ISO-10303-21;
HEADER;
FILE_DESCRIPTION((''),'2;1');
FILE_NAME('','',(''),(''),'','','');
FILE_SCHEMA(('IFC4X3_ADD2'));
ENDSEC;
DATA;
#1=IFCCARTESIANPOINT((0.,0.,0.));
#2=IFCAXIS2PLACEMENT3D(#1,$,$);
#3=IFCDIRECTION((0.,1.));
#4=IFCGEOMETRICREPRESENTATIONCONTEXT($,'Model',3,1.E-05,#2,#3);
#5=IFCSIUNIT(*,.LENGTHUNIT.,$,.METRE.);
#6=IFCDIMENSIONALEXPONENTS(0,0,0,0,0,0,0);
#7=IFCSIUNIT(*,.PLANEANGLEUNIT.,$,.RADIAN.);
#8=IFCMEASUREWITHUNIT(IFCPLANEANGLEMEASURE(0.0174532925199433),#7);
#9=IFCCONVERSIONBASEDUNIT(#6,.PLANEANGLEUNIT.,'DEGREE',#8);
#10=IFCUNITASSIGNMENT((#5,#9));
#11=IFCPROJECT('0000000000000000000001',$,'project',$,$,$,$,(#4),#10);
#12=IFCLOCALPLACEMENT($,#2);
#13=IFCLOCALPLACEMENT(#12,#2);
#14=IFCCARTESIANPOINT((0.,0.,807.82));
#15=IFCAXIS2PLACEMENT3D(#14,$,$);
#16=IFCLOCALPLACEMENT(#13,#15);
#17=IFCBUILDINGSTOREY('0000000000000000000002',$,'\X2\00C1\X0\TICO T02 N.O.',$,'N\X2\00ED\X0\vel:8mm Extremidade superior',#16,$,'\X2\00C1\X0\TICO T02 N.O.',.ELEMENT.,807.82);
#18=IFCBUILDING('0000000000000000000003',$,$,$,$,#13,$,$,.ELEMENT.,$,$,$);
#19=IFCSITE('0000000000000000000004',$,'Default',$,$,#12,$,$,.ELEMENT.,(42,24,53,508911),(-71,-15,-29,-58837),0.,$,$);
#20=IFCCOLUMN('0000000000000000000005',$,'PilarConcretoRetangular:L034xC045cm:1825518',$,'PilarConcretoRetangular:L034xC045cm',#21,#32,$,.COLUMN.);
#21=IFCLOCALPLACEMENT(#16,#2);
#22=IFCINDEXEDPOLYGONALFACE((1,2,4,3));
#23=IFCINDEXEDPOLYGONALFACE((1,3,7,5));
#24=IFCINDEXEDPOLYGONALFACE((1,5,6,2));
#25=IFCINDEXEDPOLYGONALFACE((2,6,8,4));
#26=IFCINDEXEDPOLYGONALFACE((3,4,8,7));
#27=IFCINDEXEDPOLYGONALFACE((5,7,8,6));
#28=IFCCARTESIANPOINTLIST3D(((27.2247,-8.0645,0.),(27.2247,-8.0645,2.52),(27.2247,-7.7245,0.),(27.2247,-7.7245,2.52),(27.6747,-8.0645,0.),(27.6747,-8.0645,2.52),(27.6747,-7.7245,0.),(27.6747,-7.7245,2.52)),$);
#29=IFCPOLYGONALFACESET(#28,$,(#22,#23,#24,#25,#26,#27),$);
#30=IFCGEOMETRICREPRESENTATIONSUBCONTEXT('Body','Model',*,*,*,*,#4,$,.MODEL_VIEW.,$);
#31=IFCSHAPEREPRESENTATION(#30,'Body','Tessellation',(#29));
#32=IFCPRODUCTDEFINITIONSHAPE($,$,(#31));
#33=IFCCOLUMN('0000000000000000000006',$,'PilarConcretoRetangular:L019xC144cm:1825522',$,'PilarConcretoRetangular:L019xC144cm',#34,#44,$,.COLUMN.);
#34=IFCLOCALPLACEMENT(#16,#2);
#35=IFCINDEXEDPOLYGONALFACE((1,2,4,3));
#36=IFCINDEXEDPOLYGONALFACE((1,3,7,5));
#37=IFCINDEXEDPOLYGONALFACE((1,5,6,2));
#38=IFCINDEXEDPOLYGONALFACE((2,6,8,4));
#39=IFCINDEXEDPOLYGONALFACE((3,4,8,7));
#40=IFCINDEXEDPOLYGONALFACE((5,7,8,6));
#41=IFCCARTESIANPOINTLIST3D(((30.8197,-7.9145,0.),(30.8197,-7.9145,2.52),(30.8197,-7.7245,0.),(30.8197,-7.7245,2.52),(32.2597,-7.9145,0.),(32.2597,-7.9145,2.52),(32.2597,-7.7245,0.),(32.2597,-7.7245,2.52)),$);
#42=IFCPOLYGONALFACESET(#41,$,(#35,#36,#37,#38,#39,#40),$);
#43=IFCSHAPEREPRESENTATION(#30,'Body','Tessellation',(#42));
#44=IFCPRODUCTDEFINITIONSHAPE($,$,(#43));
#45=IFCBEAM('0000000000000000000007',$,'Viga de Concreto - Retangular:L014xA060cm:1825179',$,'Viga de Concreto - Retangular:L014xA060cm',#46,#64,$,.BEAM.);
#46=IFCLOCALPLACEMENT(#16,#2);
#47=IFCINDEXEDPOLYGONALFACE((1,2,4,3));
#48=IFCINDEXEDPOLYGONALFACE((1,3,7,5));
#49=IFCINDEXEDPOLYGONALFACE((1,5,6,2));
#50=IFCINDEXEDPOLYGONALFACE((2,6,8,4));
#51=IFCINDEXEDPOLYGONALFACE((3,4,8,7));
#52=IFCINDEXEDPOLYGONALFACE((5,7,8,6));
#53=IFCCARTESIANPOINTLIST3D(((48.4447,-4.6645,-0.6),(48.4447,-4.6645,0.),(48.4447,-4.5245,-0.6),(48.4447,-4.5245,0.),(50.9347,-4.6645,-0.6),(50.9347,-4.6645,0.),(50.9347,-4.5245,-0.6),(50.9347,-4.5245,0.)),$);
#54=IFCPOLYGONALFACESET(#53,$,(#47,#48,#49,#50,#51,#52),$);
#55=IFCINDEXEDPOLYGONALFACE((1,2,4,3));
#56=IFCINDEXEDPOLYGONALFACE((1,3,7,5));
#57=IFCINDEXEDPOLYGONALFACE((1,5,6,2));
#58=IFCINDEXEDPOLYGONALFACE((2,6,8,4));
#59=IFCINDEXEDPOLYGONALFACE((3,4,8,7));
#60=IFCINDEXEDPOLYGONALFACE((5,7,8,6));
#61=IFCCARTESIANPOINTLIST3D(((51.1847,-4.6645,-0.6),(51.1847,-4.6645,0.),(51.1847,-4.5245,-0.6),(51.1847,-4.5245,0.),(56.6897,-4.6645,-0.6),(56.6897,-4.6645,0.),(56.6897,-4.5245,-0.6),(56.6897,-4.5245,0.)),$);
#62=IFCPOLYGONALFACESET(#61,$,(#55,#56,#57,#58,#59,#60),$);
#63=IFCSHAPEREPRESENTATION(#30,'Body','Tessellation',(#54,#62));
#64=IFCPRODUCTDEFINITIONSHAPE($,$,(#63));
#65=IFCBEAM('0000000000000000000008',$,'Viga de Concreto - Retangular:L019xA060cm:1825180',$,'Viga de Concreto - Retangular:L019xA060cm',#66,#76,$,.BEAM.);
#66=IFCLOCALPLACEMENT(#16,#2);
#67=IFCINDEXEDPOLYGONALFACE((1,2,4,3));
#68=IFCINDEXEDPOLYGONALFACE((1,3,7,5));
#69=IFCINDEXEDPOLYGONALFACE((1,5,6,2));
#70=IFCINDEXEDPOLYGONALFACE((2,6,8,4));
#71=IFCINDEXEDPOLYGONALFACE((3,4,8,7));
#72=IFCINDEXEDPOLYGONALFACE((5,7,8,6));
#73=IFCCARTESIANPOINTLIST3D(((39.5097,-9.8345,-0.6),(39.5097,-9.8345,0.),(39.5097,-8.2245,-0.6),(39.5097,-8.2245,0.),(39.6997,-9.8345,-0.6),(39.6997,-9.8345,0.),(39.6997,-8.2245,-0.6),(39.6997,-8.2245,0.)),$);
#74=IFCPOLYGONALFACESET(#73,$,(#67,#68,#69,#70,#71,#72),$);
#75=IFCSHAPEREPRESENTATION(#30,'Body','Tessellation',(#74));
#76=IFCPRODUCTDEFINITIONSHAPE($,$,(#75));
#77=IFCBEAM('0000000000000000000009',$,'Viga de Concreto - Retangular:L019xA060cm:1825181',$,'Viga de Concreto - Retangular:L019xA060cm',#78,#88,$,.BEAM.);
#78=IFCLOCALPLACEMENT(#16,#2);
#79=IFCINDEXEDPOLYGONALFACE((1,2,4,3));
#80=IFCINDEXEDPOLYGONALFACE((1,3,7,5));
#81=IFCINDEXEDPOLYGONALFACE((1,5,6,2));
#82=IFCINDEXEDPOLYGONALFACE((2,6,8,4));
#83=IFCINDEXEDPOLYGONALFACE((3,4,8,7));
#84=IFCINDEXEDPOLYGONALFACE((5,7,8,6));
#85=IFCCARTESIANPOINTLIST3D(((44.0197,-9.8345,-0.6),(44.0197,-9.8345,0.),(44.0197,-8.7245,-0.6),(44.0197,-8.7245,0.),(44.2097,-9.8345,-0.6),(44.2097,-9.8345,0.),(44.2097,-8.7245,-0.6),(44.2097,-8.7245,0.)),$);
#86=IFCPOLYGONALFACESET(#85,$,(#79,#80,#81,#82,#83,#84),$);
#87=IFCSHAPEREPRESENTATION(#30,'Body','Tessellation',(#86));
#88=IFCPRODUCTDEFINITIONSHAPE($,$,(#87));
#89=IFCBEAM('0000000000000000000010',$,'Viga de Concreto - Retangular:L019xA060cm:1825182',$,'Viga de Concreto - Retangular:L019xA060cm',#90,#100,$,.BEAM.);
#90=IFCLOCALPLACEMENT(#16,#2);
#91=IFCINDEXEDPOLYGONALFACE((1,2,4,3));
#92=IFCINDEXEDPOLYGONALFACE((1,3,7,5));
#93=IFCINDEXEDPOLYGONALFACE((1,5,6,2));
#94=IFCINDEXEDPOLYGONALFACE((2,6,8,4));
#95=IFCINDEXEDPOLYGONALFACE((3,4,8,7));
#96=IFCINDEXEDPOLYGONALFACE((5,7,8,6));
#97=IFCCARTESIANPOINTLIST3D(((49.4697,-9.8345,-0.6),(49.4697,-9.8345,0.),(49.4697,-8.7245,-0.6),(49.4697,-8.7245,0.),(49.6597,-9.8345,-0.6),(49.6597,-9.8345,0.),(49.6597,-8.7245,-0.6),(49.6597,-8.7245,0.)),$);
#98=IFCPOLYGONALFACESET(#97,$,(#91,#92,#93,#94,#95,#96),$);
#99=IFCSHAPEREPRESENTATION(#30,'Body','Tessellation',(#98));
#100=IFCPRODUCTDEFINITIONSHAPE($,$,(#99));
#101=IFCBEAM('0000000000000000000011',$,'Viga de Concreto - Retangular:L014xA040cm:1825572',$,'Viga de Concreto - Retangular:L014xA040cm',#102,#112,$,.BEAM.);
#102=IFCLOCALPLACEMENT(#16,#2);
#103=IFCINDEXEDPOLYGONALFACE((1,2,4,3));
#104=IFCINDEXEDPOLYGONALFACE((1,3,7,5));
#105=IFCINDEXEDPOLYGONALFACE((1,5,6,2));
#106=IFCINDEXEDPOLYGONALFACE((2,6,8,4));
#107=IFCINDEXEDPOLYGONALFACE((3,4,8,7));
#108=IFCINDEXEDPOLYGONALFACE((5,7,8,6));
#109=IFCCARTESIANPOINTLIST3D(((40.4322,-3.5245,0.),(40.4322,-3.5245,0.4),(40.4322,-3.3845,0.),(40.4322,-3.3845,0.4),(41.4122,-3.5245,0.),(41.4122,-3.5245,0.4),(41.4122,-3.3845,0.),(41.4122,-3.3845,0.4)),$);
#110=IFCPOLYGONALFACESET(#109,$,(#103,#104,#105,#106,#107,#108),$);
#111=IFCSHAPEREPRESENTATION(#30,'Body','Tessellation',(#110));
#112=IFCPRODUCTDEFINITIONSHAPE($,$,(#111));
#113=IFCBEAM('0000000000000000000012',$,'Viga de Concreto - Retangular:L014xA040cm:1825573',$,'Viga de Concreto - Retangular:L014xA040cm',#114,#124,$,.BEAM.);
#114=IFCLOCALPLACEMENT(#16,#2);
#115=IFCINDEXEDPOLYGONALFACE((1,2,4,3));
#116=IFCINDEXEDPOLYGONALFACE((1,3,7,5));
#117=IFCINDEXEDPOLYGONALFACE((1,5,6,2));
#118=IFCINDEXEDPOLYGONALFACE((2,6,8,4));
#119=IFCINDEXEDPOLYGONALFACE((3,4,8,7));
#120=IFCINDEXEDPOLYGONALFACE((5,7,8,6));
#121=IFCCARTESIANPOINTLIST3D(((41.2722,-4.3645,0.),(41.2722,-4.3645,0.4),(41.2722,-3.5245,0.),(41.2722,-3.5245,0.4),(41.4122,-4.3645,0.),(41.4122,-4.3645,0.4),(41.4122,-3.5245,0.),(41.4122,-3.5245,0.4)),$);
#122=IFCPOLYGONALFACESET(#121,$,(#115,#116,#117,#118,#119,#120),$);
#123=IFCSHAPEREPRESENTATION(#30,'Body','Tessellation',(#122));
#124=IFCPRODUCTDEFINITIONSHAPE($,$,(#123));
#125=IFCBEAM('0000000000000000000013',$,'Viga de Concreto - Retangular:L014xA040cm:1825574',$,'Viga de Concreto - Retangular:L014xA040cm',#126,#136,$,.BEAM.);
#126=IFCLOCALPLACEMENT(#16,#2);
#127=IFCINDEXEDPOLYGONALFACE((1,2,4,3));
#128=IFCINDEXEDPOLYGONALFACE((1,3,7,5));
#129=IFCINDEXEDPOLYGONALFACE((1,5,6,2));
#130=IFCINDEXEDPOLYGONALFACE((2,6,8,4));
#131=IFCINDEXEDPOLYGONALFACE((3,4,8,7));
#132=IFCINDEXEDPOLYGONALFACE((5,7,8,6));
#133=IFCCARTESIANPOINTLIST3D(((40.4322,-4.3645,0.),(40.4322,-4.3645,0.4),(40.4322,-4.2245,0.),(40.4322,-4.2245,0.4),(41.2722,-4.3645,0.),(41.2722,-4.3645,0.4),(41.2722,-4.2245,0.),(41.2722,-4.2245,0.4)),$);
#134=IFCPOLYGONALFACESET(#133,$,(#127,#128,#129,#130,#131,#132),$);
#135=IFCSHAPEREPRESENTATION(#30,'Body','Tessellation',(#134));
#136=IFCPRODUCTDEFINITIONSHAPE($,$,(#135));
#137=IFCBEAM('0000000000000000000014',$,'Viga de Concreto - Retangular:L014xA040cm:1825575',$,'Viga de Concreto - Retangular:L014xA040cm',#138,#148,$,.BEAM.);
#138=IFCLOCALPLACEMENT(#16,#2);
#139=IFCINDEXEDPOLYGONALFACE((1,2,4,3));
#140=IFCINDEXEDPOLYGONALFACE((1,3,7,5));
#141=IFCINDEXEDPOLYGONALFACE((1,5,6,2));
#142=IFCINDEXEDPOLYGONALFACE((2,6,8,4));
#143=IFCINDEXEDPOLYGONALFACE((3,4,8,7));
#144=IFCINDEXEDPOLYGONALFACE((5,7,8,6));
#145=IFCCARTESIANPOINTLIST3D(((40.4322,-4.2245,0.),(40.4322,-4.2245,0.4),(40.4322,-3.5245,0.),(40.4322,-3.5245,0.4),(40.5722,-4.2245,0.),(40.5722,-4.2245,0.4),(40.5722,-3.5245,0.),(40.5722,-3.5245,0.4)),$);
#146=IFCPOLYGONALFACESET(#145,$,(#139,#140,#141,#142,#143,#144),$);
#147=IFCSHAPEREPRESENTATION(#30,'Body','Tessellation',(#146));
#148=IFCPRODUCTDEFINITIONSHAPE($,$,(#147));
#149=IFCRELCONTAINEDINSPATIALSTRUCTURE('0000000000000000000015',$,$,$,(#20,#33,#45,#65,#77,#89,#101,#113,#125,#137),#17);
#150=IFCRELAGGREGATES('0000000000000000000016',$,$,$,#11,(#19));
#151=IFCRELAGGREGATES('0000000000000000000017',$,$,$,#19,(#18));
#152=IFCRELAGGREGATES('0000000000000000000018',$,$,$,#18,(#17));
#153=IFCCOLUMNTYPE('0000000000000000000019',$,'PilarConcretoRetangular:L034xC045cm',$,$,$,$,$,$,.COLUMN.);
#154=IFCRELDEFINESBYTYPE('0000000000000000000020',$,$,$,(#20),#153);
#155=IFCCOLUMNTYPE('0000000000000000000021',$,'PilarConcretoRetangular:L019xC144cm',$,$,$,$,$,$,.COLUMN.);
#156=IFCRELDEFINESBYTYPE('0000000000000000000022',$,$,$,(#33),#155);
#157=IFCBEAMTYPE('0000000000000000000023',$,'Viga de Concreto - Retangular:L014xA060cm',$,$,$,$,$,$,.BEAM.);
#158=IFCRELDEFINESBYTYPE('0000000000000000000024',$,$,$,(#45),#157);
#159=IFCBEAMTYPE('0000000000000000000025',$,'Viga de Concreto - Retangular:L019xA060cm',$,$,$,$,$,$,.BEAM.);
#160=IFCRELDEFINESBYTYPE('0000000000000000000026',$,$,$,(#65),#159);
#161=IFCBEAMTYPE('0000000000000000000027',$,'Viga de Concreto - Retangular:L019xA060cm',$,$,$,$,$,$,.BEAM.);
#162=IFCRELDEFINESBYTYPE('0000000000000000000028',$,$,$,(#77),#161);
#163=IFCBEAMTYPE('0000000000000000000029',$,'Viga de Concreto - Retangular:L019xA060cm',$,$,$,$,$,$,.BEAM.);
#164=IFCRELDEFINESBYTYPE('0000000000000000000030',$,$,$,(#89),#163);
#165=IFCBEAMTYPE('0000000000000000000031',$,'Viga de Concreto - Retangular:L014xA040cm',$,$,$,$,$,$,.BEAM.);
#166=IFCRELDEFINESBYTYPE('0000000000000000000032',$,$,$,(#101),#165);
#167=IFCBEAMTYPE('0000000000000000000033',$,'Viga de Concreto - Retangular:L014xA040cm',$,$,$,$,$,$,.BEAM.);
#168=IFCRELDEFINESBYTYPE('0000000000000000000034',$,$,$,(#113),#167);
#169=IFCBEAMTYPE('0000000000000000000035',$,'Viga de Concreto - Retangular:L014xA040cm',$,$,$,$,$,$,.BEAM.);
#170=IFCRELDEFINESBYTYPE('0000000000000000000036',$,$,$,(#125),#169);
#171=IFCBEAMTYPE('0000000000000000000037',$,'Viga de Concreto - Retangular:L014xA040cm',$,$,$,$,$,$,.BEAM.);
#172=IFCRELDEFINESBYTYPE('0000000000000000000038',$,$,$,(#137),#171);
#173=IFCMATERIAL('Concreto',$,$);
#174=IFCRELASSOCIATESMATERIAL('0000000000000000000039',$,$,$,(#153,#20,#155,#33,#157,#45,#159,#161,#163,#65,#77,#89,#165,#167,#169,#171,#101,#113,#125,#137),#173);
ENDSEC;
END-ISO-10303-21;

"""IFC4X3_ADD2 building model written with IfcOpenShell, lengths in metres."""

from ifc_helpers import new_model, entity, si_unit, converted_unit, direction, frame, frame_2d, origin, origin_2d_with_axis, place, context, subcontext, project, spatial, rectangle, extrude, source, transform, mapped, material, material_profile, profile_set, profile_usage, type_object, type_shapes, element, save


model = new_model("IFC4X3_ADD2")

# Units and contexts
model_context = context("Model", 3, precision=1e-05, world=origin(), true_north=direction((0.0, 1.0)))
body_context = subcontext(model_context, "Body", "Model", "MODEL_VIEW")
ifc_project = project(units=[si_unit("LENGTHUNIT", "METRE"), converted_unit("PLANEANGLEUNIT", "DEGREE", entity("IfcPlaneAngleMeasure", 0.0174532925199433), si_unit("PLANEANGLEUNIT", "RADIAN"), dimensions=[0, 0, 0, 0, 0, 0, 0])], contexts=[model_context])

# Site, building, storey
site_placement = place(None, origin())
site = spatial("IfcSite", under=ifc_project, at=site_placement, Name="Default", CompositionType="ELEMENT", RefLatitude=(42, 24, 53, 508911), RefLongitude=(-71, -15, -29, -58837), RefElevation=0.0)
building_placement = place(site_placement, origin())
building = spatial("IfcBuilding", under=site, at=building_placement, CompositionType="ELEMENT")
storey_placement = place(building_placement, frame((0.0, 0.0, 807.82)))
storey = spatial("IfcBuildingStorey", under=building, at=storey_placement, Name="ÁTICO T02 N.O.", ObjectType="Nível:8mm Extremidade superior", LongName="ÁTICO T02 N.O.", CompositionType="ELEMENT", Elevation=807.82)

# Columns
ifc_material = material(Name="Concreto")
ifc_material_profile_1 = material_profile(ifc_material, rectangle(XDim=0.34, YDim=0.45, at=origin_2d_with_axis()), Name="L034xC045cm")
ifc_profile_set_1 = profile_set([ifc_material_profile_1], Name="L034xC045cm")
ifc_profile_usage_1 = profile_usage(ifc_profile_set_1)
column_type_1 = type_object("IfcColumnType", Name="PilarConcretoRetangular:L034xC045cm", PredefinedType="COLUMN", material=ifc_profile_set_1)
shared_shape_1 = source(origin(), body_context, "Body", "SweptSolid", [
    extrude(rectangle(XDim=0.34, YDim=0.45, at=origin_2d_with_axis()), frame((27.4497, -7.8945, 807.82), z_axis=(0.0, 0.0, 1.0), x_axis=(0.0, -1.0, 0.0)), (0.0, 0.0, 1.0), 2.52),
])
type_shapes(column_type_1, [shared_shape_1])
column_1_placement = place(storey_placement, frame((0.0, 0.0, -807.82)))
element("IfcColumn", 1, at=column_1_placement, inside=storey, type_object=column_type_1, material=ifc_profile_usage_1, Name="PilarConcretoRetangular:L034xC045cm:1825518", ObjectType="PilarConcretoRetangular:L034xC045cm", PredefinedType="COLUMN", context=body_context, shape_type="MappedRepresentation", body=[
    mapped(shared_shape_1, transform((0.0, 0.0, 0.0), scale=1.0)),
])
ifc_material_profile_2 = material_profile(ifc_material, rectangle(XDim=0.19, YDim=1.44, at=frame_2d((0.0, 0.0), x_axis=(1.0, 0.0))), Name="L019xC144cm")
ifc_profile_set_2 = profile_set([ifc_material_profile_2], Name="L019xC144cm")
ifc_profile_usage_2 = profile_usage(ifc_profile_set_2)
column_type_2 = type_object("IfcColumnType", Name="PilarConcretoRetangular:L019xC144cm", PredefinedType="COLUMN", material=ifc_profile_set_2)
shared_shape_2 = source(origin(), body_context, "Body", "SweptSolid", [
    extrude(rectangle(XDim=0.19, YDim=1.44, at=frame_2d((0.0, 0.0), x_axis=(1.0, 0.0))), frame((31.5397, -7.8195, 807.82), z_axis=(0.0, 0.0, 1.0), x_axis=(0.0, 1.0, 0.0)), (0.0, 0.0, 1.0), 2.52),
])
type_shapes(column_type_2, [shared_shape_2])
column_2_placement = place(storey_placement, frame((0.0, 0.0, -807.82)))
element("IfcColumn", 2, at=column_2_placement, inside=storey, type_object=column_type_2, material=ifc_profile_usage_2, Name="PilarConcretoRetangular:L019xC144cm:1825522", ObjectType="PilarConcretoRetangular:L019xC144cm", PredefinedType="COLUMN", context=body_context, shape_type="MappedRepresentation", body=[
    mapped(shared_shape_2, transform((0.0, 0.0, 0.0), scale=1.0)),
])

# Beams
ifc_material_profile_3 = material_profile(ifc_material, rectangle(XDim=0.6, YDim=0.14, at=origin_2d_with_axis()), Name="L014xA060cm")
ifc_profile_set_3 = profile_set([ifc_material_profile_3], Name="L014xA060cm")
ifc_profile_usage_3 = profile_usage(ifc_profile_set_3, cardinal=8)
beam_type_1 = type_object("IfcBeamType", Name="Viga de Concreto - Retangular:L014xA060cm", PredefinedType="BEAM", material=ifc_profile_set_3)
shared_shape_3 = source(origin(), body_context, "Body", "SweptSolid", [
    extrude(rectangle(XDim=0.6, YDim=0.14, at=origin_2d_with_axis()), frame((48.4447, -4.5945, 807.52), z_axis=(1.0, 0.0, 0.0), x_axis=(0.0, 0.0, -1.0)), (0.0, 0.0, 1.0), 2.49),
    extrude(rectangle(XDim=0.6, YDim=0.14, at=frame_2d((0.0, 0.0), x_axis=(1.0, 0.0))), frame((51.1847, -4.5945, 807.52), z_axis=(1.0, 0.0, 0.0), x_axis=(0.0, 0.0, -1.0)), (0.0, 0.0, 1.0), 5.505),
])
type_shapes(beam_type_1, [shared_shape_3])
beam_1_placement = place(storey_placement, frame((0.0, 0.0, -807.82)))
element("IfcBeam", 3, at=beam_1_placement, inside=storey, type_object=beam_type_1, material=ifc_profile_usage_3, Name="Viga de Concreto - Retangular:L014xA060cm:1825179", ObjectType="Viga de Concreto - Retangular:L014xA060cm", PredefinedType="BEAM", context=body_context, shape_type="MappedRepresentation", body=[
    mapped(shared_shape_3, transform((0.0, 0.0, 0.0), scale=1.0)),
])
ifc_material_profile_4 = material_profile(ifc_material, rectangle(XDim=0.6, YDim=0.19, at=origin_2d_with_axis()), Name="L019xA060cm")
ifc_profile_set_4 = profile_set([ifc_material_profile_4], Name="L019xA060cm")
ifc_profile_usage_4 = profile_usage(ifc_profile_set_4, cardinal=8)
beam_type_2 = type_object("IfcBeamType", Name="Viga de Concreto - Retangular:L019xA060cm", PredefinedType="BEAM", material=ifc_profile_set_4)
shared_shape_4 = source(origin(), body_context, "Body", "SweptSolid", [
    extrude(rectangle(XDim=0.6, YDim=0.19, at=frame_2d((0.0, 0.0), x_axis=(0.0, 1.0))), frame((39.6047, -8.2245, 807.52), z_axis=(0.0, -1.0, 0.0), x_axis=(-1.0, 0.0, 0.0)), (0.0, 0.0, 1.0), 1.61),
])
type_shapes(beam_type_2, [shared_shape_4])
beam_2_placement = place(storey_placement, frame((0.0, 0.0, -807.82)))
element("IfcBeam", 4, at=beam_2_placement, inside=storey, type_object=beam_type_2, material=ifc_profile_usage_4, Name="Viga de Concreto - Retangular:L019xA060cm:1825180", ObjectType="Viga de Concreto - Retangular:L019xA060cm", PredefinedType="BEAM", context=body_context, shape_type="MappedRepresentation", body=[
    mapped(shared_shape_4, transform((0.0, 0.0, 0.0), scale=1.0)),
])
beam_type_3 = type_object("IfcBeamType", Name="Viga de Concreto - Retangular:L019xA060cm", PredefinedType="BEAM", material=ifc_profile_set_4)
shared_shape_5 = source(origin(), body_context, "Body", "SweptSolid", [
    extrude(rectangle(XDim=0.6, YDim=0.19, at=frame_2d((0.0, 0.0), x_axis=(0.0, 1.0))), frame((44.1147, -8.7245, 807.52), z_axis=(0.0, -1.0, 0.0), x_axis=(-1.0, 0.0, 0.0)), (0.0, 0.0, 1.0), 1.11),
])
type_shapes(beam_type_3, [shared_shape_5])
beam_3_placement = place(storey_placement, frame((0.0, 0.0, -807.82)))
element("IfcBeam", 5, at=beam_3_placement, inside=storey, type_object=beam_type_3, material=ifc_profile_usage_4, Name="Viga de Concreto - Retangular:L019xA060cm:1825181", ObjectType="Viga de Concreto - Retangular:L019xA060cm", PredefinedType="BEAM", context=body_context, shape_type="MappedRepresentation", body=[
    mapped(shared_shape_5, transform((0.0, 0.0, 0.0), scale=1.0)),
])
beam_type_4 = type_object("IfcBeamType", Name="Viga de Concreto - Retangular:L019xA060cm", PredefinedType="BEAM", material=ifc_profile_set_4)
shared_shape_6 = source(origin(), body_context, "Body", "SweptSolid", [
    extrude(rectangle(XDim=0.6, YDim=0.19, at=frame_2d((0.0, 0.0), x_axis=(0.0, 1.0))), frame((49.5647, -8.7245, 807.52), z_axis=(0.0, -1.0, 0.0), x_axis=(-1.0, 0.0, 0.0)), (0.0, 0.0, 1.0), 1.11),
])
type_shapes(beam_type_4, [shared_shape_6])
beam_4_placement = place(storey_placement, frame((0.0, 0.0, -807.82)))
element("IfcBeam", 6, at=beam_4_placement, inside=storey, type_object=beam_type_4, material=ifc_profile_usage_4, Name="Viga de Concreto - Retangular:L019xA060cm:1825182", ObjectType="Viga de Concreto - Retangular:L019xA060cm", PredefinedType="BEAM", context=body_context, shape_type="MappedRepresentation", body=[
    mapped(shared_shape_6, transform((0.0, 0.0, 0.0), scale=1.0)),
])
ifc_material_profile_5 = material_profile(ifc_material, rectangle(XDim=0.4, YDim=0.14, at=frame_2d((0.0, 0.0), x_axis=(0.0, 1.0))), Name="L014xA040cm")
ifc_profile_set_5 = profile_set([ifc_material_profile_5], Name="L014xA040cm")
ifc_profile_usage_5 = profile_usage(ifc_profile_set_5, cardinal=8)
beam_type_5 = type_object("IfcBeamType", Name="Viga de Concreto - Retangular:L014xA040cm", PredefinedType="BEAM", material=ifc_profile_set_5)
shared_shape_7 = source(origin(), body_context, "Body", "SweptSolid", [
    extrude(rectangle(XDim=0.4, YDim=0.14, at=frame_2d((0.0, 0.0), x_axis=(1.0, 0.0))), frame((40.4322, -3.4545, 808.02), z_axis=(1.0, 0.0, 0.0), x_axis=(0.0, 0.0, -1.0)), (0.0, 0.0, 1.0), 0.98),
])
type_shapes(beam_type_5, [shared_shape_7])
beam_5_placement = place(storey_placement, frame((0.0, 0.0, -807.82)))
element("IfcBeam", 7, at=beam_5_placement, inside=storey, type_object=beam_type_5, material=ifc_profile_usage_5, Name="Viga de Concreto - Retangular:L014xA040cm:1825572", ObjectType="Viga de Concreto - Retangular:L014xA040cm", PredefinedType="BEAM", context=body_context, shape_type="MappedRepresentation", body=[
    mapped(shared_shape_7, transform((0.0, 0.0, 0.0), scale=1.0)),
])
beam_type_6 = type_object("IfcBeamType", Name="Viga de Concreto - Retangular:L014xA040cm", PredefinedType="BEAM", material=ifc_profile_set_5)
shared_shape_8 = source(origin(), body_context, "Body", "SweptSolid", [
    extrude(rectangle(XDim=0.4, YDim=0.14, at=frame_2d((0.0, 0.0), x_axis=(0.0, 1.0))), frame((41.3422, -3.5245, 808.02), z_axis=(0.0, -1.0, 0.0), x_axis=(-1.0, 0.0, 0.0)), (0.0, 0.0, 1.0), 0.84),
])
type_shapes(beam_type_6, [shared_shape_8])
beam_6_placement = place(storey_placement, frame((0.0, 0.0, -807.82)))
element("IfcBeam", 8, at=beam_6_placement, inside=storey, type_object=beam_type_6, material=ifc_profile_usage_5, Name="Viga de Concreto - Retangular:L014xA040cm:1825573", ObjectType="Viga de Concreto - Retangular:L014xA040cm", PredefinedType="BEAM", context=body_context, shape_type="MappedRepresentation", body=[
    mapped(shared_shape_8, transform((0.0, 0.0, 0.0), scale=1.0)),
])
beam_type_7 = type_object("IfcBeamType", Name="Viga de Concreto - Retangular:L014xA040cm", PredefinedType="BEAM", material=ifc_profile_set_5)
shared_shape_9 = source(origin(), body_context, "Body", "SweptSolid", [
    extrude(rectangle(XDim=0.4, YDim=0.14, at=origin_2d_with_axis()), frame((41.2722, -4.2945, 808.02), z_axis=(-1.0, 0.0, 0.0), x_axis=(0.0, 0.0, -1.0)), (0.0, 0.0, 1.0), 0.84),
])
type_shapes(beam_type_7, [shared_shape_9])
beam_7_placement = place(storey_placement, frame((0.0, 0.0, -807.82)))
element("IfcBeam", 9, at=beam_7_placement, inside=storey, type_object=beam_type_7, material=ifc_profile_usage_5, Name="Viga de Concreto - Retangular:L014xA040cm:1825574", ObjectType="Viga de Concreto - Retangular:L014xA040cm", PredefinedType="BEAM", context=body_context, shape_type="MappedRepresentation", body=[
    mapped(shared_shape_9, transform((0.0, 0.0, 0.0), scale=1.0)),
])
beam_type_8 = type_object("IfcBeamType", Name="Viga de Concreto - Retangular:L014xA040cm", PredefinedType="BEAM", material=ifc_profile_set_5)
shared_shape_10 = source(origin(), body_context, "Body", "SweptSolid", [
    extrude(rectangle(XDim=0.4, YDim=0.14, at=frame_2d((0.0, 0.0), x_axis=(0.0, 1.0))), frame((40.5022, -4.2245, 808.02), z_axis=(0.0, 1.0, 0.0), x_axis=(-1.0, 0.0, 0.0)), (0.0, 0.0, 1.0), 0.7),
])
type_shapes(beam_type_8, [shared_shape_10])
beam_8_placement = place(storey_placement, frame((0.0, 0.0, -807.82)))
element("IfcBeam", 10, at=beam_8_placement, inside=storey, type_object=beam_type_8, material=ifc_profile_usage_5, Name="Viga de Concreto - Retangular:L014xA040cm:1825575", ObjectType="Viga de Concreto - Retangular:L014xA040cm", PredefinedType="BEAM", context=body_context, shape_type="MappedRepresentation", body=[
    mapped(shared_shape_10, transform((0.0, 0.0, 0.0), scale=1.0)),
])

save(model, "model.ifc")
